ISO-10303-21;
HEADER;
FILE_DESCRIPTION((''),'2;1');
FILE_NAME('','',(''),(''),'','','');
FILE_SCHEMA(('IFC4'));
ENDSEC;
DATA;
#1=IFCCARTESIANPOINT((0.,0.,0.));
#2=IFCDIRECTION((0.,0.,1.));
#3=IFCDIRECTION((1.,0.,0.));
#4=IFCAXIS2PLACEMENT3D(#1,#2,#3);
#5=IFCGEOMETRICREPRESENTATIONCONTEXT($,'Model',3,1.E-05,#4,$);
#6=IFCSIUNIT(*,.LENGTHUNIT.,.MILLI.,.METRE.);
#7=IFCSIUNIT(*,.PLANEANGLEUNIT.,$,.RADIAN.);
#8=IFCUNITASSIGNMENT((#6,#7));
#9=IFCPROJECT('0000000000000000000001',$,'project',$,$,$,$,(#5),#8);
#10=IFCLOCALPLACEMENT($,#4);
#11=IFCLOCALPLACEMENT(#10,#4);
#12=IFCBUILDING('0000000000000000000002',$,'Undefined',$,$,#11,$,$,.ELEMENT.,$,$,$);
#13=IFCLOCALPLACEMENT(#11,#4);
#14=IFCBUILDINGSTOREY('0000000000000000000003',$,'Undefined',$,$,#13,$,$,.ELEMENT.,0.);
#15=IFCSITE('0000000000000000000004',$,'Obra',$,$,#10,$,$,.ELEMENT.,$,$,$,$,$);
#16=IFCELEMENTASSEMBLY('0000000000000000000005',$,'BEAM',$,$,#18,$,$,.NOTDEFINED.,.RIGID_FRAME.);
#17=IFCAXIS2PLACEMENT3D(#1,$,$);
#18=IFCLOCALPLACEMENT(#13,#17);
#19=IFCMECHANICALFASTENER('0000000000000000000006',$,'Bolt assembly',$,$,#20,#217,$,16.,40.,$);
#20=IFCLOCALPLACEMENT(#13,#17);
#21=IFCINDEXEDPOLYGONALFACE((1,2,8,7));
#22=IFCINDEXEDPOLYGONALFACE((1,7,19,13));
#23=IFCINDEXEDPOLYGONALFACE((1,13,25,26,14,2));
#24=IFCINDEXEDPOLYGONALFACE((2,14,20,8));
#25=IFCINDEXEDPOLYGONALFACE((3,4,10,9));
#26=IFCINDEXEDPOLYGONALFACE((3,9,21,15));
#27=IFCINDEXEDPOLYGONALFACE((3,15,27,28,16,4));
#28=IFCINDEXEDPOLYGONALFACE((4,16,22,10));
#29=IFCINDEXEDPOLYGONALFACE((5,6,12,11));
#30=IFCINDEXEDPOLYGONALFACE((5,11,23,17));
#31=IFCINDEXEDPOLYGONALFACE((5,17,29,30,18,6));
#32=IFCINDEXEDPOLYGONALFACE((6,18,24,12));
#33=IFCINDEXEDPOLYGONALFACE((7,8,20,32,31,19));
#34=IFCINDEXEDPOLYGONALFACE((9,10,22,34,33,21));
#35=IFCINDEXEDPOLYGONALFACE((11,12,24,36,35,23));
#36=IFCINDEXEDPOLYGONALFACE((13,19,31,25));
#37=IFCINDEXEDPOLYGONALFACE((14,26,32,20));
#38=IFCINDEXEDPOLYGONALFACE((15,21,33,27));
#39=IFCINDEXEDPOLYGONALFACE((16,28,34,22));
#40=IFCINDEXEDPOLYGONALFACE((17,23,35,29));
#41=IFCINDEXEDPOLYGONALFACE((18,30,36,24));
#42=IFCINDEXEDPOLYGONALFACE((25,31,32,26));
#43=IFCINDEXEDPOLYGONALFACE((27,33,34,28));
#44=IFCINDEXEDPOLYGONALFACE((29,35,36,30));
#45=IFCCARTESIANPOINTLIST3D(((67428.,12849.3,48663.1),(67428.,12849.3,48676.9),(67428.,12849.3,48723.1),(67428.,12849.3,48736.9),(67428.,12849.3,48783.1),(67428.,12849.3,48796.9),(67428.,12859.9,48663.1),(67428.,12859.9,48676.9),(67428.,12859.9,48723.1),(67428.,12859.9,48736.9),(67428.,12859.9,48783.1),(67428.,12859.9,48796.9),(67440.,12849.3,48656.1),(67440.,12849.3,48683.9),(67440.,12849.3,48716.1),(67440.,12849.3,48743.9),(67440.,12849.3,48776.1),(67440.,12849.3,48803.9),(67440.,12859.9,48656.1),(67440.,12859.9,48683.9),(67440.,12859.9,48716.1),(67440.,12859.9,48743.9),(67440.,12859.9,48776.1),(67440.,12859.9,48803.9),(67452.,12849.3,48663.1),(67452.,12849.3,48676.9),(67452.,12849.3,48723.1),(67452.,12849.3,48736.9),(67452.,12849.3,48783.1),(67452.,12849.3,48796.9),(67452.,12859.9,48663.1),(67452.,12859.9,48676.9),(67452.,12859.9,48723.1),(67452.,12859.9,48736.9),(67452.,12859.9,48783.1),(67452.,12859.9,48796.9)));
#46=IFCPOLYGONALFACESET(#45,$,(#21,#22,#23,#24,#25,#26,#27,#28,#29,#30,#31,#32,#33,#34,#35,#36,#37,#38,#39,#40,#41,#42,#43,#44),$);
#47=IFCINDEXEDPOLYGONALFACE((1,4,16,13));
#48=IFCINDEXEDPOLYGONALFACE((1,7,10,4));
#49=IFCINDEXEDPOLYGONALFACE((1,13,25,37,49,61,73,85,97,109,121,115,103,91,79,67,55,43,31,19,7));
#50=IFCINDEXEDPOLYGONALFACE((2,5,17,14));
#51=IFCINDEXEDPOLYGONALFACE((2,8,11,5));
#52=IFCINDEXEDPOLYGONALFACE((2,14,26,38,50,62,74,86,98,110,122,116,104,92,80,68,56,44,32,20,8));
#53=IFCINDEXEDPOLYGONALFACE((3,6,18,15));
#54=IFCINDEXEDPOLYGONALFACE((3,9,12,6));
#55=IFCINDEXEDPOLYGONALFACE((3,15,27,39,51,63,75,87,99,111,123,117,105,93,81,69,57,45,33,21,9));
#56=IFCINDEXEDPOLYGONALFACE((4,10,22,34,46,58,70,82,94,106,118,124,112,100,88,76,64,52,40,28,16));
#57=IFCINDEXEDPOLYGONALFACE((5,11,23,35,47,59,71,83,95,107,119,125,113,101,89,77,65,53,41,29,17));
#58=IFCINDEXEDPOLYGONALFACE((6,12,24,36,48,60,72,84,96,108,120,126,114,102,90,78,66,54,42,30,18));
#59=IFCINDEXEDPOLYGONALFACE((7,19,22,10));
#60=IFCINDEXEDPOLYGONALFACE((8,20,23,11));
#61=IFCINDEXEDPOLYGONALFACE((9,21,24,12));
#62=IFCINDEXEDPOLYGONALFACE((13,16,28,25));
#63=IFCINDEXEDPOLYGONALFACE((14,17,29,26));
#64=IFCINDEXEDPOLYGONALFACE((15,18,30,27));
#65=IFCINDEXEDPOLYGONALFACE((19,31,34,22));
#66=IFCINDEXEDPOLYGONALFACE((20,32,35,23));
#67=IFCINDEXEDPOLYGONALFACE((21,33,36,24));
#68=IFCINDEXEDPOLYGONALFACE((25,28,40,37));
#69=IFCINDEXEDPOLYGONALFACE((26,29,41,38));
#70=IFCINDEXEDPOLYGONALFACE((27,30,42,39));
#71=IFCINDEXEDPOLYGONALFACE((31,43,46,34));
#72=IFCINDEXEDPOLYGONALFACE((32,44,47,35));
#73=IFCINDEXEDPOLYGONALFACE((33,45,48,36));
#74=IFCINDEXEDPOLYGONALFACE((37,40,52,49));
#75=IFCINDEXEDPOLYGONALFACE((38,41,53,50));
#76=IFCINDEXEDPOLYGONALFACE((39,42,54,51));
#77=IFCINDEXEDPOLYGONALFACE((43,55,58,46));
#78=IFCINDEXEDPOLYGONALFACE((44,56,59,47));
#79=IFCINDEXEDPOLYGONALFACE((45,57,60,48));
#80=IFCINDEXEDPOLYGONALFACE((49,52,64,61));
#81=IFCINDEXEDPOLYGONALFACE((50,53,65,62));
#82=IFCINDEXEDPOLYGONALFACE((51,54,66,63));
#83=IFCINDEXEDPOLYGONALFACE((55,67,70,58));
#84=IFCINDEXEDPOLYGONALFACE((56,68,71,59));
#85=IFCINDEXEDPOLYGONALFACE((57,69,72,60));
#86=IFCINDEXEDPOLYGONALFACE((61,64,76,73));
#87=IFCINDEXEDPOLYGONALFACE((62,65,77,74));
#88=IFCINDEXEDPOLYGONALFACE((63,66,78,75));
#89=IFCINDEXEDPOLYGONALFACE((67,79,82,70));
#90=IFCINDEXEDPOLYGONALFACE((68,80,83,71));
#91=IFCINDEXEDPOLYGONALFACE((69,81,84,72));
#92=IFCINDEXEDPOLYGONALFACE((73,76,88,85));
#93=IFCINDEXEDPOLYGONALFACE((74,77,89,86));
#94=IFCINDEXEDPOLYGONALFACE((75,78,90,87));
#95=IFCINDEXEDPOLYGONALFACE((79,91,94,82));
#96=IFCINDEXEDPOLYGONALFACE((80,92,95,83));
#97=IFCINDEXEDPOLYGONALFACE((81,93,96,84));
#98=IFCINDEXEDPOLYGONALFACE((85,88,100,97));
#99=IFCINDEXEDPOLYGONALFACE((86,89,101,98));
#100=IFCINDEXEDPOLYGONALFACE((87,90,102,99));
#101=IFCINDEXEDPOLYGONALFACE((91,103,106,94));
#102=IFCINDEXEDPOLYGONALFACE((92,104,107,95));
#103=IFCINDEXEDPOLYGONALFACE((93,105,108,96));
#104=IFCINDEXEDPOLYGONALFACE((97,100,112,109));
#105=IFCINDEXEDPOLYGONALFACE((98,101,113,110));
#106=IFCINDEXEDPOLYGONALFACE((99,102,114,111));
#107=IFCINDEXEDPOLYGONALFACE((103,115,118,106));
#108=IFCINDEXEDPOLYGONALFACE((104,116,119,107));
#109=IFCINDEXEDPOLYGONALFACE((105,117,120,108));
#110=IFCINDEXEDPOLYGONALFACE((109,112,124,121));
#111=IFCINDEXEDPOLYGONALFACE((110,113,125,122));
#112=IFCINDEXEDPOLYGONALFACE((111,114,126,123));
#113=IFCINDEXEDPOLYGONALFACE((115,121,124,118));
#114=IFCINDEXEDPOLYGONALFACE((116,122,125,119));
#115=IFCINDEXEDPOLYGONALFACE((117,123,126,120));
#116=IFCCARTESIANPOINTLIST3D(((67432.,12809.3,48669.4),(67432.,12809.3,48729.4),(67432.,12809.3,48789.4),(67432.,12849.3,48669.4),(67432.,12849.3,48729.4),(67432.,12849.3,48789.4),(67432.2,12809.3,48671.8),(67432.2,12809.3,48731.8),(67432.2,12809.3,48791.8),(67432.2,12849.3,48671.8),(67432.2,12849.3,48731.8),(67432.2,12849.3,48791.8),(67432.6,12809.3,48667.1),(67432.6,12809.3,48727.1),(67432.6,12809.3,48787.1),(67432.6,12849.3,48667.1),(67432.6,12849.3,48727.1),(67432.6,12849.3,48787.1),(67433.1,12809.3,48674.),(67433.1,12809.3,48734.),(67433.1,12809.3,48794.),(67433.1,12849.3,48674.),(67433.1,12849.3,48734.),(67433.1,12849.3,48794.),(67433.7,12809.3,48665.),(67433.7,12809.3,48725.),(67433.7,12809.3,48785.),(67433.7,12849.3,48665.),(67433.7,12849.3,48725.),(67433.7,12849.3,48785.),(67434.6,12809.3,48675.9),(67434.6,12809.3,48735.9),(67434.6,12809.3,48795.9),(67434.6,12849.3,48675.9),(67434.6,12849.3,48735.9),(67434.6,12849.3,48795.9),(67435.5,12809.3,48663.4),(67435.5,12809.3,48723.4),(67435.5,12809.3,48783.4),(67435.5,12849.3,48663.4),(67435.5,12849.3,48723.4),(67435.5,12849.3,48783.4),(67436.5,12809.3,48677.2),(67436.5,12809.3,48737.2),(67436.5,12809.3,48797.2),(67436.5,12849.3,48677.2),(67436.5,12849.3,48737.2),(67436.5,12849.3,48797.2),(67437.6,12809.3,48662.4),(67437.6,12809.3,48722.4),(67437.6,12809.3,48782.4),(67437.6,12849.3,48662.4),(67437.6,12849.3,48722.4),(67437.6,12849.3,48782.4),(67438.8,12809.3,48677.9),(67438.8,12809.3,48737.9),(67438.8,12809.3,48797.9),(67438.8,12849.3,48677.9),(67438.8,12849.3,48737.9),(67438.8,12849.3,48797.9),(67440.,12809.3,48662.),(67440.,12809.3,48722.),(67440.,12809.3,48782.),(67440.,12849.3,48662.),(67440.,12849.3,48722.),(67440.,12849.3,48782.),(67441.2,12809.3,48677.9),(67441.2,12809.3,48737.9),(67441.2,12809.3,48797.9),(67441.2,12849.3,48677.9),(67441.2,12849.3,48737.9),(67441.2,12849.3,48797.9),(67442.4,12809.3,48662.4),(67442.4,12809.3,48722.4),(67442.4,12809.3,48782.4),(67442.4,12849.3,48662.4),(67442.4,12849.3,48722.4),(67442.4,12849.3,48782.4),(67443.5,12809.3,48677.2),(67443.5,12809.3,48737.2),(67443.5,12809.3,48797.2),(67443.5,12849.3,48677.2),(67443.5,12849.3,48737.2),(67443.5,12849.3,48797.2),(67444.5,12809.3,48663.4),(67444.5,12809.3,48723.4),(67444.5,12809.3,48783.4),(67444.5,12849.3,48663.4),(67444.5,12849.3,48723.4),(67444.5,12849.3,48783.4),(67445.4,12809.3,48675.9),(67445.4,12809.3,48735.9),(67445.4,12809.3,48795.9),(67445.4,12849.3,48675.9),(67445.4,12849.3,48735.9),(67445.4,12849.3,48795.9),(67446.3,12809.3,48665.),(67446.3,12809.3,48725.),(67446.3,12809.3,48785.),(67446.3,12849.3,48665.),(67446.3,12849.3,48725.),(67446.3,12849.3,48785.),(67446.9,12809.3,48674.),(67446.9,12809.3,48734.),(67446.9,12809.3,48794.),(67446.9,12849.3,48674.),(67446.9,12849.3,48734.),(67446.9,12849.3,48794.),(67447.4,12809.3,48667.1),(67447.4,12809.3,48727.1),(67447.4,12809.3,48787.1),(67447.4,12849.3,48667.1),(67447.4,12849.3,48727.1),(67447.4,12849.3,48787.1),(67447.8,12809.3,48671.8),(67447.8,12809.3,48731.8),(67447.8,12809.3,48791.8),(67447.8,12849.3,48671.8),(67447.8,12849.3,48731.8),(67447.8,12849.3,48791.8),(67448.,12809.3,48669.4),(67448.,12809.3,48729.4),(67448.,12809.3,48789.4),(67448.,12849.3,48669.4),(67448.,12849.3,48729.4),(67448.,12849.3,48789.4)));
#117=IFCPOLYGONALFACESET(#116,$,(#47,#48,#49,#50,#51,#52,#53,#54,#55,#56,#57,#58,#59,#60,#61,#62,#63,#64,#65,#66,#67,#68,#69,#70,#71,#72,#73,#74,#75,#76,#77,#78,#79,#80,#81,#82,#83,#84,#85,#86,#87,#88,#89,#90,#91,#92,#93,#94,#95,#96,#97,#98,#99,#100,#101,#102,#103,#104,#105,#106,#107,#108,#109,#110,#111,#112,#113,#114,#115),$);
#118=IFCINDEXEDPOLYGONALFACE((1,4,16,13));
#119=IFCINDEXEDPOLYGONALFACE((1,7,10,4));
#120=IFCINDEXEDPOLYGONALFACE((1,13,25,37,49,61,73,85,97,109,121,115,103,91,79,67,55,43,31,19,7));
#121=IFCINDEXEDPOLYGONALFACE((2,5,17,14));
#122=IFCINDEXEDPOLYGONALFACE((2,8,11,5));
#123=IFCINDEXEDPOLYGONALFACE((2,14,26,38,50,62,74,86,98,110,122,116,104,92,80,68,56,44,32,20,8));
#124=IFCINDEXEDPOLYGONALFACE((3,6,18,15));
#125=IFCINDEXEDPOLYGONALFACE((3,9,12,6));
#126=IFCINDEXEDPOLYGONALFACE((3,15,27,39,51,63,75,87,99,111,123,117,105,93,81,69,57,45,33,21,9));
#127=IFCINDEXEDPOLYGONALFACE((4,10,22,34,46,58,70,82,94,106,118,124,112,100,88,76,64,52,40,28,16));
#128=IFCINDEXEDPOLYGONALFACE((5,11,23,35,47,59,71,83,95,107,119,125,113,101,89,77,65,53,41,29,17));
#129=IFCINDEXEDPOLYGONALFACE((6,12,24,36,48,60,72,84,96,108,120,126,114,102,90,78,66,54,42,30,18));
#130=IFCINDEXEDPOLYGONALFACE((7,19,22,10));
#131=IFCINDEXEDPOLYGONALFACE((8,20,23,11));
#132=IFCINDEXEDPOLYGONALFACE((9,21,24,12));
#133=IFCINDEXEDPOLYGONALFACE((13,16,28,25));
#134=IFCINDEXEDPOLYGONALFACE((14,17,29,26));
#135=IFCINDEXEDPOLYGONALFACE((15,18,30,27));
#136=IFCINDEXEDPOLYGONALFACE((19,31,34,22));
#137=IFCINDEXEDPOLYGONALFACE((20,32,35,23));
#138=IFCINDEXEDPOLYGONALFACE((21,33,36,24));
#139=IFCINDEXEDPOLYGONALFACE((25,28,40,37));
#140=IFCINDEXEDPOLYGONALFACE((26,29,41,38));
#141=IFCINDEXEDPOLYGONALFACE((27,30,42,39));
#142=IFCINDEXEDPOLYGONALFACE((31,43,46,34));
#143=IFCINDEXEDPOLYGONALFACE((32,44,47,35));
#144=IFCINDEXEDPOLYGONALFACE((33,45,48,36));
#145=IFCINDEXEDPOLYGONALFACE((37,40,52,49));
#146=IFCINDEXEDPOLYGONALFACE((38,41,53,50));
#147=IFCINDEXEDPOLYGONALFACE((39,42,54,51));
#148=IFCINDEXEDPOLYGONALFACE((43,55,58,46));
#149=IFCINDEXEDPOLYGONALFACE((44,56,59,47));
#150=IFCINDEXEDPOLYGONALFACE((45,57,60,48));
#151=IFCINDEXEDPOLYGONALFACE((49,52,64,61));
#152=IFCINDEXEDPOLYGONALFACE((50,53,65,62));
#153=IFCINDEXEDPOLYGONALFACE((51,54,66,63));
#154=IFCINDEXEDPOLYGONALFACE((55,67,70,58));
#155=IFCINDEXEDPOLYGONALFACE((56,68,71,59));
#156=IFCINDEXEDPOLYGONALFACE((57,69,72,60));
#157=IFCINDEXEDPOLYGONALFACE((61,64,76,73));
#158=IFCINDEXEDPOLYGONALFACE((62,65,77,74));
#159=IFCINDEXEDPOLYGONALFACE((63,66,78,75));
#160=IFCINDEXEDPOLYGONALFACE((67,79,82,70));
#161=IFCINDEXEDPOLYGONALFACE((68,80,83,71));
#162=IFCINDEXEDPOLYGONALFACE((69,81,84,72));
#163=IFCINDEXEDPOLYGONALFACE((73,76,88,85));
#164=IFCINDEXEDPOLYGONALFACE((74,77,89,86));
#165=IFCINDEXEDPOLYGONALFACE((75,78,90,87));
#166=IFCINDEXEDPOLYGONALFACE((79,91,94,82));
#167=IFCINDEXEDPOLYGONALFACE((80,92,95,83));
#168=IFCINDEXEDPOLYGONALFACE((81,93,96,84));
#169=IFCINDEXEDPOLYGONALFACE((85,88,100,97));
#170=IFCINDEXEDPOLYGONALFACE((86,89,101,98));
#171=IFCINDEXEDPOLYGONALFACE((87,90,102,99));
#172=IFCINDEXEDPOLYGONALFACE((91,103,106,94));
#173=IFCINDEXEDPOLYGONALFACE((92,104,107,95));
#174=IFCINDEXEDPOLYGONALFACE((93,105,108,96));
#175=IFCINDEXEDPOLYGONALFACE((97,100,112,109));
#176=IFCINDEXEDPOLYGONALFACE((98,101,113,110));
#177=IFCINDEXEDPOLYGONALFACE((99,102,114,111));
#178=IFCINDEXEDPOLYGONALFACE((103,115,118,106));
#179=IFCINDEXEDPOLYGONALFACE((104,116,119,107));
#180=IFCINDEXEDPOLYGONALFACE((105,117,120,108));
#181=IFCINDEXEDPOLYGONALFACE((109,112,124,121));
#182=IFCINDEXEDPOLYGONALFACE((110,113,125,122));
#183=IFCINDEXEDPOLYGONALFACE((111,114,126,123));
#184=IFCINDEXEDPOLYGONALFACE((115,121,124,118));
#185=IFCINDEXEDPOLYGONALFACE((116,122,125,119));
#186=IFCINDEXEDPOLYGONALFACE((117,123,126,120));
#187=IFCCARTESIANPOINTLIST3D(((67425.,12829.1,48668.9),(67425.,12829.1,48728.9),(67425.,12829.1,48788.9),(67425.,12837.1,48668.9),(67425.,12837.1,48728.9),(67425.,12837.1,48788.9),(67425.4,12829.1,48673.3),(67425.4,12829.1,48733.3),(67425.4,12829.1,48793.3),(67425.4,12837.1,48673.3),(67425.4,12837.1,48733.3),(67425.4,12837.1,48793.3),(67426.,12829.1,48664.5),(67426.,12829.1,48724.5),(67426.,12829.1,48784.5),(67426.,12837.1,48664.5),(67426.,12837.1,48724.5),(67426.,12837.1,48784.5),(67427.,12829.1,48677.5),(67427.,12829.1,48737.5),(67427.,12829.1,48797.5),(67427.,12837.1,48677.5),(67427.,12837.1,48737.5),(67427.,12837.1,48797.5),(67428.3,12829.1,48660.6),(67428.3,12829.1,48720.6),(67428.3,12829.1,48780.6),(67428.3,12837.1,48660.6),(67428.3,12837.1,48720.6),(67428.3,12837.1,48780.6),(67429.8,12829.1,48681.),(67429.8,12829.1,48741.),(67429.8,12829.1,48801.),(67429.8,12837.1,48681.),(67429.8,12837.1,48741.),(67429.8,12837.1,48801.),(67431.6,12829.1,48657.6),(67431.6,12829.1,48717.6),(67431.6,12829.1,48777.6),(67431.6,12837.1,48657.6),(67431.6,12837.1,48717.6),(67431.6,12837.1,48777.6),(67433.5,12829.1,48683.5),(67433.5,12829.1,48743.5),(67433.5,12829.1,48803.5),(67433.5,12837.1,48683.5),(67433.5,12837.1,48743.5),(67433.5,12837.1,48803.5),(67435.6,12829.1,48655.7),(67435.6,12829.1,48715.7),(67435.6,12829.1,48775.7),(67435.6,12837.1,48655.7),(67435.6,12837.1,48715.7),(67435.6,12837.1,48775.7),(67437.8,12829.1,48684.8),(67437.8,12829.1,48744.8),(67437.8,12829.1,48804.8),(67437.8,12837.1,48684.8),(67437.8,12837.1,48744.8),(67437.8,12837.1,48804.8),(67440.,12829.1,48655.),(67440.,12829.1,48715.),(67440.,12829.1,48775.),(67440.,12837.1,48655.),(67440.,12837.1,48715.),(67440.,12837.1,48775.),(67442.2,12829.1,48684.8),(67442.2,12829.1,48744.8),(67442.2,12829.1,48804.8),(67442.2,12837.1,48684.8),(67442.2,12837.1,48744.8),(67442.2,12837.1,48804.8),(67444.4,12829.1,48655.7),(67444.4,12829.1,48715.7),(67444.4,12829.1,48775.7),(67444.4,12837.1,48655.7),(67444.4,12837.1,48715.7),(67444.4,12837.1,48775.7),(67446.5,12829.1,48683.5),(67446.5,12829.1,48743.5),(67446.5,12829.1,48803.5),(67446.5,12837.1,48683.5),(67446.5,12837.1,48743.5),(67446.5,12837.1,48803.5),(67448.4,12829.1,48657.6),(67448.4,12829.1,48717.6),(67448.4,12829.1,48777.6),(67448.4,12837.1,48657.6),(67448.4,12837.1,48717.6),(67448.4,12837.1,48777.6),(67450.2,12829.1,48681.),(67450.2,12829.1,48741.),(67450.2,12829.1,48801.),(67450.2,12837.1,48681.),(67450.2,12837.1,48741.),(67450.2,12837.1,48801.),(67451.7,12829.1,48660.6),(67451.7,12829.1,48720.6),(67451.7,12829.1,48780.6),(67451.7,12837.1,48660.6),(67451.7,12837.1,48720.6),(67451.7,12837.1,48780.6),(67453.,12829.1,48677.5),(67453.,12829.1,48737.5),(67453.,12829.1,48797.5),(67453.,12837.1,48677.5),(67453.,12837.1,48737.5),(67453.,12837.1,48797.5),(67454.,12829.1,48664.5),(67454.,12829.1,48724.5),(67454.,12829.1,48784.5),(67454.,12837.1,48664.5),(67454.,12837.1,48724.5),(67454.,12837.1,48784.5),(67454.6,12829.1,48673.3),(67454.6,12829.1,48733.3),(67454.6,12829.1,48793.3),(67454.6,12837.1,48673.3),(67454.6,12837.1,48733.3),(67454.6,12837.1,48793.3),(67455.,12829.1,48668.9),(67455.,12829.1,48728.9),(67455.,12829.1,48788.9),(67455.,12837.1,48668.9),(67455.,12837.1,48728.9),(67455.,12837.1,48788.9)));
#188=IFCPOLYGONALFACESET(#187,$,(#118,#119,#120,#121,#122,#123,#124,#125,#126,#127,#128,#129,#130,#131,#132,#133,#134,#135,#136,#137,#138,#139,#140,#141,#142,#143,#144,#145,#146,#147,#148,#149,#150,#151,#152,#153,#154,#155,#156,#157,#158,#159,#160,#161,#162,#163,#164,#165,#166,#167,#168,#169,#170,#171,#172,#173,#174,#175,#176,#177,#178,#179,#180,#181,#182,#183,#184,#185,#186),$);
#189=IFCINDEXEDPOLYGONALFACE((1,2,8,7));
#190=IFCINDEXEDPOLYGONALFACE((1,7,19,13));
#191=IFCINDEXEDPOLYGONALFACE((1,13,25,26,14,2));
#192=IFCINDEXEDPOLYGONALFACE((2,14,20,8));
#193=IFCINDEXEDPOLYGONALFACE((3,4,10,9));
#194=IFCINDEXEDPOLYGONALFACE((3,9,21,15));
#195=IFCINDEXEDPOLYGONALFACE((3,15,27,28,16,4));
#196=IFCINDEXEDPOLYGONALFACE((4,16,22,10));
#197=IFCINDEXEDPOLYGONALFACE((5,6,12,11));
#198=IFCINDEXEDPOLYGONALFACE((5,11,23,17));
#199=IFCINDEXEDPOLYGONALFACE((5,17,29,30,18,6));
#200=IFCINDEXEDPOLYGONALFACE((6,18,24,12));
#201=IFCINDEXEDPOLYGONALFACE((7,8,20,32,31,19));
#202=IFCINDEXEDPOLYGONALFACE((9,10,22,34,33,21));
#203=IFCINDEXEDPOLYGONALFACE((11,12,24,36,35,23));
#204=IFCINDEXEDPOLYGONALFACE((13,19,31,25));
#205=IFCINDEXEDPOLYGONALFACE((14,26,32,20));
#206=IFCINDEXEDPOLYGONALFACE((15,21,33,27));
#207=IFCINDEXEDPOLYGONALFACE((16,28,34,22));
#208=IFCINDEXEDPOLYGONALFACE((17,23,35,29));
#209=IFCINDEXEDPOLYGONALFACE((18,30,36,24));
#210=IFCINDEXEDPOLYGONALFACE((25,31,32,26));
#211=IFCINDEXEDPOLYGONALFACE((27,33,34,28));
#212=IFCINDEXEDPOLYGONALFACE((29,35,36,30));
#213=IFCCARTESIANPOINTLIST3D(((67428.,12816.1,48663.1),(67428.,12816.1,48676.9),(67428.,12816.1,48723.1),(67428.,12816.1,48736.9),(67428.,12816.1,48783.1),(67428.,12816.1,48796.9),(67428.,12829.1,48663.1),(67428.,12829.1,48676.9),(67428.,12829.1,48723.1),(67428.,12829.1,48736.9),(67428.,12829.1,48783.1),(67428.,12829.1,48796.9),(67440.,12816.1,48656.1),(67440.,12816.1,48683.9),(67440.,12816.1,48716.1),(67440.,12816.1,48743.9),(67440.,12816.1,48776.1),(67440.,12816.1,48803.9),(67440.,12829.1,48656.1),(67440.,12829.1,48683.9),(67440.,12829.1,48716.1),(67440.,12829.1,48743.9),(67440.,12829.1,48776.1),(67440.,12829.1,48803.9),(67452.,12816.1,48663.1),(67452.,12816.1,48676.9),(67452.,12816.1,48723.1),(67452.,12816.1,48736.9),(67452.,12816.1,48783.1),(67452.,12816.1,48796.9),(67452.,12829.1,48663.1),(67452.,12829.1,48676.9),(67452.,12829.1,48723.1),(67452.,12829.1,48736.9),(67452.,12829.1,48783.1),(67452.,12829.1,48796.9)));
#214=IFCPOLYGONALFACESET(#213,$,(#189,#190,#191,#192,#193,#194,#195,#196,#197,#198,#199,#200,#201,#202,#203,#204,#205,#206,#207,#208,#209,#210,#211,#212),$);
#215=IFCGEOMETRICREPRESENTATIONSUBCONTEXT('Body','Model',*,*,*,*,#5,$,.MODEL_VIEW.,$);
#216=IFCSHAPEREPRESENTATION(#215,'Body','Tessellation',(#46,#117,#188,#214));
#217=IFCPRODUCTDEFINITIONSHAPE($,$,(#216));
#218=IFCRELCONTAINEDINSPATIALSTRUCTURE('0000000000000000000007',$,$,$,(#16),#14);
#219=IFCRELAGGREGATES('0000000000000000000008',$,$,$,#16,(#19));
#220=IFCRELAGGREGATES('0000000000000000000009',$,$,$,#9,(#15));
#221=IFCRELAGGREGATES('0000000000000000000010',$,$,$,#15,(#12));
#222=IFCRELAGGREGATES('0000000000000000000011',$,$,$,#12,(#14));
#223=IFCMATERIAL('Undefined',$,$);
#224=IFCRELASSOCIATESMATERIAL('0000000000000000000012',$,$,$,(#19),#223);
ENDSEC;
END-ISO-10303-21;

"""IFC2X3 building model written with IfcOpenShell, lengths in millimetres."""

from ifc_helpers import new_model, si_unit, frame, origin_with_axes, origin_2d_with_axis, place, context, subcontext, project, spatial, polyline, circle, outline, extrude, source, transform, mapped, material, element, aggregate, save


model = new_model("IFC2X3")

# Units and contexts
model_context = context("Model", 3, precision=1e-05, world=origin_with_axes())
body_context = subcontext(model_context, "Body", "Model", "MODEL_VIEW")
ifc_project = project(units=[si_unit("LENGTHUNIT", "METRE", prefix="MILLI"), si_unit("PLANEANGLEUNIT", "RADIAN")], contexts=[model_context])

# Site, building, storey
site_placement = place(None, origin_with_axes())
site = spatial("IfcSite", under=ifc_project, at=site_placement, Name="Obra", CompositionType="ELEMENT")
building_placement = place(site_placement, origin_with_axes())
building = spatial("IfcBuilding", under=site, at=building_placement, Name="Undefined", CompositionType="ELEMENT")
storey_placement = place(building_placement, origin_with_axes())
storey = spatial("IfcBuildingStorey", under=building, at=storey_placement, Name="Undefined", CompositionType="ELEMENT", Elevation=0.0)

# Element assembly, mechanical fastener
ifc_material_1 = material(Name="Undefined")
assembly_1_placement = place(storey_placement, origin_with_axes())
assembly_1 = element("IfcElementAssembly", 1, at=assembly_1_placement, inside=storey, Name="BEAM", AssemblyPlace="NOTDEFINED", PredefinedType="RIGID_FRAME")
shared_shape_1 = source(origin_with_axes(), body_context, "Body", "SweptSolid", [
    extrude(outline(polyline([(13.9, 0.0), (6.9, 12.0), (-6.9, 12.0), (-13.9, 0.0), (-6.9, -12.0), (6.9, -12.0), (13.9, 0.0)])), frame((0.0, -19.7, 0.0), z_axis=(0.0, 1.0, 0.0), x_axis=(1.0, 0.0, 0.0)), (0.0, 0.0, 1.0), 10.6),
    extrude(circle(Radius=8.0, at=origin_2d_with_axis()), frame((0.0, -9.1, 0.0), z_axis=(0.0, 1.0, 0.0), x_axis=(1.0, 0.0, 0.0)), (0.0, 0.0, 1.0), 40.0),
    extrude(circle(Radius=15.0, at=origin_2d_with_axis()), frame((0.0, 3.1, 0.0), z_axis=(0.0, 1.0, 0.0), x_axis=(1.0, 0.0, 0.0)), (0.0, 0.0, 1.0), 8.0),
    extrude(outline(polyline([(13.9, 0.0), (6.9, 12.0), (-6.9, 12.0), (-13.9, 0.0), (-6.9, -12.0), (6.9, -12.0), (13.9, 0.0)])), frame((0.0, 11.1, 0.0), z_axis=(0.0, 1.0, 0.0), x_axis=(1.0, 0.0, 0.0)), (0.0, 0.0, 1.0), 13.0),
])
mechanical_fastener_1_placement = place(assembly_1_placement, frame((67490.0, 12840.2, 48850.0), z_axis=(-1.0, 0.0, 0.0), x_axis=(0.0, 0.0, -1.0)))
mechanical_fastener_1 = element("IfcMechanicalFastener", 2, at=mechanical_fastener_1_placement, material=ifc_material_1, Name="Bolt assembly", NominalDiameter=16.0, NominalLength=40.0, context=body_context, shape_type="MappedRepresentation", body=[
    mapped(shared_shape_1, transform((60.0, 0.0, 50.0))),
    mapped(shared_shape_1, transform((120.0, 0.0, 50.0))),
    mapped(shared_shape_1, transform((180.0, 0.0, 50.0))),
])
aggregate(assembly_1, [mechanical_fastener_1])

save(model, "model.ifc")
